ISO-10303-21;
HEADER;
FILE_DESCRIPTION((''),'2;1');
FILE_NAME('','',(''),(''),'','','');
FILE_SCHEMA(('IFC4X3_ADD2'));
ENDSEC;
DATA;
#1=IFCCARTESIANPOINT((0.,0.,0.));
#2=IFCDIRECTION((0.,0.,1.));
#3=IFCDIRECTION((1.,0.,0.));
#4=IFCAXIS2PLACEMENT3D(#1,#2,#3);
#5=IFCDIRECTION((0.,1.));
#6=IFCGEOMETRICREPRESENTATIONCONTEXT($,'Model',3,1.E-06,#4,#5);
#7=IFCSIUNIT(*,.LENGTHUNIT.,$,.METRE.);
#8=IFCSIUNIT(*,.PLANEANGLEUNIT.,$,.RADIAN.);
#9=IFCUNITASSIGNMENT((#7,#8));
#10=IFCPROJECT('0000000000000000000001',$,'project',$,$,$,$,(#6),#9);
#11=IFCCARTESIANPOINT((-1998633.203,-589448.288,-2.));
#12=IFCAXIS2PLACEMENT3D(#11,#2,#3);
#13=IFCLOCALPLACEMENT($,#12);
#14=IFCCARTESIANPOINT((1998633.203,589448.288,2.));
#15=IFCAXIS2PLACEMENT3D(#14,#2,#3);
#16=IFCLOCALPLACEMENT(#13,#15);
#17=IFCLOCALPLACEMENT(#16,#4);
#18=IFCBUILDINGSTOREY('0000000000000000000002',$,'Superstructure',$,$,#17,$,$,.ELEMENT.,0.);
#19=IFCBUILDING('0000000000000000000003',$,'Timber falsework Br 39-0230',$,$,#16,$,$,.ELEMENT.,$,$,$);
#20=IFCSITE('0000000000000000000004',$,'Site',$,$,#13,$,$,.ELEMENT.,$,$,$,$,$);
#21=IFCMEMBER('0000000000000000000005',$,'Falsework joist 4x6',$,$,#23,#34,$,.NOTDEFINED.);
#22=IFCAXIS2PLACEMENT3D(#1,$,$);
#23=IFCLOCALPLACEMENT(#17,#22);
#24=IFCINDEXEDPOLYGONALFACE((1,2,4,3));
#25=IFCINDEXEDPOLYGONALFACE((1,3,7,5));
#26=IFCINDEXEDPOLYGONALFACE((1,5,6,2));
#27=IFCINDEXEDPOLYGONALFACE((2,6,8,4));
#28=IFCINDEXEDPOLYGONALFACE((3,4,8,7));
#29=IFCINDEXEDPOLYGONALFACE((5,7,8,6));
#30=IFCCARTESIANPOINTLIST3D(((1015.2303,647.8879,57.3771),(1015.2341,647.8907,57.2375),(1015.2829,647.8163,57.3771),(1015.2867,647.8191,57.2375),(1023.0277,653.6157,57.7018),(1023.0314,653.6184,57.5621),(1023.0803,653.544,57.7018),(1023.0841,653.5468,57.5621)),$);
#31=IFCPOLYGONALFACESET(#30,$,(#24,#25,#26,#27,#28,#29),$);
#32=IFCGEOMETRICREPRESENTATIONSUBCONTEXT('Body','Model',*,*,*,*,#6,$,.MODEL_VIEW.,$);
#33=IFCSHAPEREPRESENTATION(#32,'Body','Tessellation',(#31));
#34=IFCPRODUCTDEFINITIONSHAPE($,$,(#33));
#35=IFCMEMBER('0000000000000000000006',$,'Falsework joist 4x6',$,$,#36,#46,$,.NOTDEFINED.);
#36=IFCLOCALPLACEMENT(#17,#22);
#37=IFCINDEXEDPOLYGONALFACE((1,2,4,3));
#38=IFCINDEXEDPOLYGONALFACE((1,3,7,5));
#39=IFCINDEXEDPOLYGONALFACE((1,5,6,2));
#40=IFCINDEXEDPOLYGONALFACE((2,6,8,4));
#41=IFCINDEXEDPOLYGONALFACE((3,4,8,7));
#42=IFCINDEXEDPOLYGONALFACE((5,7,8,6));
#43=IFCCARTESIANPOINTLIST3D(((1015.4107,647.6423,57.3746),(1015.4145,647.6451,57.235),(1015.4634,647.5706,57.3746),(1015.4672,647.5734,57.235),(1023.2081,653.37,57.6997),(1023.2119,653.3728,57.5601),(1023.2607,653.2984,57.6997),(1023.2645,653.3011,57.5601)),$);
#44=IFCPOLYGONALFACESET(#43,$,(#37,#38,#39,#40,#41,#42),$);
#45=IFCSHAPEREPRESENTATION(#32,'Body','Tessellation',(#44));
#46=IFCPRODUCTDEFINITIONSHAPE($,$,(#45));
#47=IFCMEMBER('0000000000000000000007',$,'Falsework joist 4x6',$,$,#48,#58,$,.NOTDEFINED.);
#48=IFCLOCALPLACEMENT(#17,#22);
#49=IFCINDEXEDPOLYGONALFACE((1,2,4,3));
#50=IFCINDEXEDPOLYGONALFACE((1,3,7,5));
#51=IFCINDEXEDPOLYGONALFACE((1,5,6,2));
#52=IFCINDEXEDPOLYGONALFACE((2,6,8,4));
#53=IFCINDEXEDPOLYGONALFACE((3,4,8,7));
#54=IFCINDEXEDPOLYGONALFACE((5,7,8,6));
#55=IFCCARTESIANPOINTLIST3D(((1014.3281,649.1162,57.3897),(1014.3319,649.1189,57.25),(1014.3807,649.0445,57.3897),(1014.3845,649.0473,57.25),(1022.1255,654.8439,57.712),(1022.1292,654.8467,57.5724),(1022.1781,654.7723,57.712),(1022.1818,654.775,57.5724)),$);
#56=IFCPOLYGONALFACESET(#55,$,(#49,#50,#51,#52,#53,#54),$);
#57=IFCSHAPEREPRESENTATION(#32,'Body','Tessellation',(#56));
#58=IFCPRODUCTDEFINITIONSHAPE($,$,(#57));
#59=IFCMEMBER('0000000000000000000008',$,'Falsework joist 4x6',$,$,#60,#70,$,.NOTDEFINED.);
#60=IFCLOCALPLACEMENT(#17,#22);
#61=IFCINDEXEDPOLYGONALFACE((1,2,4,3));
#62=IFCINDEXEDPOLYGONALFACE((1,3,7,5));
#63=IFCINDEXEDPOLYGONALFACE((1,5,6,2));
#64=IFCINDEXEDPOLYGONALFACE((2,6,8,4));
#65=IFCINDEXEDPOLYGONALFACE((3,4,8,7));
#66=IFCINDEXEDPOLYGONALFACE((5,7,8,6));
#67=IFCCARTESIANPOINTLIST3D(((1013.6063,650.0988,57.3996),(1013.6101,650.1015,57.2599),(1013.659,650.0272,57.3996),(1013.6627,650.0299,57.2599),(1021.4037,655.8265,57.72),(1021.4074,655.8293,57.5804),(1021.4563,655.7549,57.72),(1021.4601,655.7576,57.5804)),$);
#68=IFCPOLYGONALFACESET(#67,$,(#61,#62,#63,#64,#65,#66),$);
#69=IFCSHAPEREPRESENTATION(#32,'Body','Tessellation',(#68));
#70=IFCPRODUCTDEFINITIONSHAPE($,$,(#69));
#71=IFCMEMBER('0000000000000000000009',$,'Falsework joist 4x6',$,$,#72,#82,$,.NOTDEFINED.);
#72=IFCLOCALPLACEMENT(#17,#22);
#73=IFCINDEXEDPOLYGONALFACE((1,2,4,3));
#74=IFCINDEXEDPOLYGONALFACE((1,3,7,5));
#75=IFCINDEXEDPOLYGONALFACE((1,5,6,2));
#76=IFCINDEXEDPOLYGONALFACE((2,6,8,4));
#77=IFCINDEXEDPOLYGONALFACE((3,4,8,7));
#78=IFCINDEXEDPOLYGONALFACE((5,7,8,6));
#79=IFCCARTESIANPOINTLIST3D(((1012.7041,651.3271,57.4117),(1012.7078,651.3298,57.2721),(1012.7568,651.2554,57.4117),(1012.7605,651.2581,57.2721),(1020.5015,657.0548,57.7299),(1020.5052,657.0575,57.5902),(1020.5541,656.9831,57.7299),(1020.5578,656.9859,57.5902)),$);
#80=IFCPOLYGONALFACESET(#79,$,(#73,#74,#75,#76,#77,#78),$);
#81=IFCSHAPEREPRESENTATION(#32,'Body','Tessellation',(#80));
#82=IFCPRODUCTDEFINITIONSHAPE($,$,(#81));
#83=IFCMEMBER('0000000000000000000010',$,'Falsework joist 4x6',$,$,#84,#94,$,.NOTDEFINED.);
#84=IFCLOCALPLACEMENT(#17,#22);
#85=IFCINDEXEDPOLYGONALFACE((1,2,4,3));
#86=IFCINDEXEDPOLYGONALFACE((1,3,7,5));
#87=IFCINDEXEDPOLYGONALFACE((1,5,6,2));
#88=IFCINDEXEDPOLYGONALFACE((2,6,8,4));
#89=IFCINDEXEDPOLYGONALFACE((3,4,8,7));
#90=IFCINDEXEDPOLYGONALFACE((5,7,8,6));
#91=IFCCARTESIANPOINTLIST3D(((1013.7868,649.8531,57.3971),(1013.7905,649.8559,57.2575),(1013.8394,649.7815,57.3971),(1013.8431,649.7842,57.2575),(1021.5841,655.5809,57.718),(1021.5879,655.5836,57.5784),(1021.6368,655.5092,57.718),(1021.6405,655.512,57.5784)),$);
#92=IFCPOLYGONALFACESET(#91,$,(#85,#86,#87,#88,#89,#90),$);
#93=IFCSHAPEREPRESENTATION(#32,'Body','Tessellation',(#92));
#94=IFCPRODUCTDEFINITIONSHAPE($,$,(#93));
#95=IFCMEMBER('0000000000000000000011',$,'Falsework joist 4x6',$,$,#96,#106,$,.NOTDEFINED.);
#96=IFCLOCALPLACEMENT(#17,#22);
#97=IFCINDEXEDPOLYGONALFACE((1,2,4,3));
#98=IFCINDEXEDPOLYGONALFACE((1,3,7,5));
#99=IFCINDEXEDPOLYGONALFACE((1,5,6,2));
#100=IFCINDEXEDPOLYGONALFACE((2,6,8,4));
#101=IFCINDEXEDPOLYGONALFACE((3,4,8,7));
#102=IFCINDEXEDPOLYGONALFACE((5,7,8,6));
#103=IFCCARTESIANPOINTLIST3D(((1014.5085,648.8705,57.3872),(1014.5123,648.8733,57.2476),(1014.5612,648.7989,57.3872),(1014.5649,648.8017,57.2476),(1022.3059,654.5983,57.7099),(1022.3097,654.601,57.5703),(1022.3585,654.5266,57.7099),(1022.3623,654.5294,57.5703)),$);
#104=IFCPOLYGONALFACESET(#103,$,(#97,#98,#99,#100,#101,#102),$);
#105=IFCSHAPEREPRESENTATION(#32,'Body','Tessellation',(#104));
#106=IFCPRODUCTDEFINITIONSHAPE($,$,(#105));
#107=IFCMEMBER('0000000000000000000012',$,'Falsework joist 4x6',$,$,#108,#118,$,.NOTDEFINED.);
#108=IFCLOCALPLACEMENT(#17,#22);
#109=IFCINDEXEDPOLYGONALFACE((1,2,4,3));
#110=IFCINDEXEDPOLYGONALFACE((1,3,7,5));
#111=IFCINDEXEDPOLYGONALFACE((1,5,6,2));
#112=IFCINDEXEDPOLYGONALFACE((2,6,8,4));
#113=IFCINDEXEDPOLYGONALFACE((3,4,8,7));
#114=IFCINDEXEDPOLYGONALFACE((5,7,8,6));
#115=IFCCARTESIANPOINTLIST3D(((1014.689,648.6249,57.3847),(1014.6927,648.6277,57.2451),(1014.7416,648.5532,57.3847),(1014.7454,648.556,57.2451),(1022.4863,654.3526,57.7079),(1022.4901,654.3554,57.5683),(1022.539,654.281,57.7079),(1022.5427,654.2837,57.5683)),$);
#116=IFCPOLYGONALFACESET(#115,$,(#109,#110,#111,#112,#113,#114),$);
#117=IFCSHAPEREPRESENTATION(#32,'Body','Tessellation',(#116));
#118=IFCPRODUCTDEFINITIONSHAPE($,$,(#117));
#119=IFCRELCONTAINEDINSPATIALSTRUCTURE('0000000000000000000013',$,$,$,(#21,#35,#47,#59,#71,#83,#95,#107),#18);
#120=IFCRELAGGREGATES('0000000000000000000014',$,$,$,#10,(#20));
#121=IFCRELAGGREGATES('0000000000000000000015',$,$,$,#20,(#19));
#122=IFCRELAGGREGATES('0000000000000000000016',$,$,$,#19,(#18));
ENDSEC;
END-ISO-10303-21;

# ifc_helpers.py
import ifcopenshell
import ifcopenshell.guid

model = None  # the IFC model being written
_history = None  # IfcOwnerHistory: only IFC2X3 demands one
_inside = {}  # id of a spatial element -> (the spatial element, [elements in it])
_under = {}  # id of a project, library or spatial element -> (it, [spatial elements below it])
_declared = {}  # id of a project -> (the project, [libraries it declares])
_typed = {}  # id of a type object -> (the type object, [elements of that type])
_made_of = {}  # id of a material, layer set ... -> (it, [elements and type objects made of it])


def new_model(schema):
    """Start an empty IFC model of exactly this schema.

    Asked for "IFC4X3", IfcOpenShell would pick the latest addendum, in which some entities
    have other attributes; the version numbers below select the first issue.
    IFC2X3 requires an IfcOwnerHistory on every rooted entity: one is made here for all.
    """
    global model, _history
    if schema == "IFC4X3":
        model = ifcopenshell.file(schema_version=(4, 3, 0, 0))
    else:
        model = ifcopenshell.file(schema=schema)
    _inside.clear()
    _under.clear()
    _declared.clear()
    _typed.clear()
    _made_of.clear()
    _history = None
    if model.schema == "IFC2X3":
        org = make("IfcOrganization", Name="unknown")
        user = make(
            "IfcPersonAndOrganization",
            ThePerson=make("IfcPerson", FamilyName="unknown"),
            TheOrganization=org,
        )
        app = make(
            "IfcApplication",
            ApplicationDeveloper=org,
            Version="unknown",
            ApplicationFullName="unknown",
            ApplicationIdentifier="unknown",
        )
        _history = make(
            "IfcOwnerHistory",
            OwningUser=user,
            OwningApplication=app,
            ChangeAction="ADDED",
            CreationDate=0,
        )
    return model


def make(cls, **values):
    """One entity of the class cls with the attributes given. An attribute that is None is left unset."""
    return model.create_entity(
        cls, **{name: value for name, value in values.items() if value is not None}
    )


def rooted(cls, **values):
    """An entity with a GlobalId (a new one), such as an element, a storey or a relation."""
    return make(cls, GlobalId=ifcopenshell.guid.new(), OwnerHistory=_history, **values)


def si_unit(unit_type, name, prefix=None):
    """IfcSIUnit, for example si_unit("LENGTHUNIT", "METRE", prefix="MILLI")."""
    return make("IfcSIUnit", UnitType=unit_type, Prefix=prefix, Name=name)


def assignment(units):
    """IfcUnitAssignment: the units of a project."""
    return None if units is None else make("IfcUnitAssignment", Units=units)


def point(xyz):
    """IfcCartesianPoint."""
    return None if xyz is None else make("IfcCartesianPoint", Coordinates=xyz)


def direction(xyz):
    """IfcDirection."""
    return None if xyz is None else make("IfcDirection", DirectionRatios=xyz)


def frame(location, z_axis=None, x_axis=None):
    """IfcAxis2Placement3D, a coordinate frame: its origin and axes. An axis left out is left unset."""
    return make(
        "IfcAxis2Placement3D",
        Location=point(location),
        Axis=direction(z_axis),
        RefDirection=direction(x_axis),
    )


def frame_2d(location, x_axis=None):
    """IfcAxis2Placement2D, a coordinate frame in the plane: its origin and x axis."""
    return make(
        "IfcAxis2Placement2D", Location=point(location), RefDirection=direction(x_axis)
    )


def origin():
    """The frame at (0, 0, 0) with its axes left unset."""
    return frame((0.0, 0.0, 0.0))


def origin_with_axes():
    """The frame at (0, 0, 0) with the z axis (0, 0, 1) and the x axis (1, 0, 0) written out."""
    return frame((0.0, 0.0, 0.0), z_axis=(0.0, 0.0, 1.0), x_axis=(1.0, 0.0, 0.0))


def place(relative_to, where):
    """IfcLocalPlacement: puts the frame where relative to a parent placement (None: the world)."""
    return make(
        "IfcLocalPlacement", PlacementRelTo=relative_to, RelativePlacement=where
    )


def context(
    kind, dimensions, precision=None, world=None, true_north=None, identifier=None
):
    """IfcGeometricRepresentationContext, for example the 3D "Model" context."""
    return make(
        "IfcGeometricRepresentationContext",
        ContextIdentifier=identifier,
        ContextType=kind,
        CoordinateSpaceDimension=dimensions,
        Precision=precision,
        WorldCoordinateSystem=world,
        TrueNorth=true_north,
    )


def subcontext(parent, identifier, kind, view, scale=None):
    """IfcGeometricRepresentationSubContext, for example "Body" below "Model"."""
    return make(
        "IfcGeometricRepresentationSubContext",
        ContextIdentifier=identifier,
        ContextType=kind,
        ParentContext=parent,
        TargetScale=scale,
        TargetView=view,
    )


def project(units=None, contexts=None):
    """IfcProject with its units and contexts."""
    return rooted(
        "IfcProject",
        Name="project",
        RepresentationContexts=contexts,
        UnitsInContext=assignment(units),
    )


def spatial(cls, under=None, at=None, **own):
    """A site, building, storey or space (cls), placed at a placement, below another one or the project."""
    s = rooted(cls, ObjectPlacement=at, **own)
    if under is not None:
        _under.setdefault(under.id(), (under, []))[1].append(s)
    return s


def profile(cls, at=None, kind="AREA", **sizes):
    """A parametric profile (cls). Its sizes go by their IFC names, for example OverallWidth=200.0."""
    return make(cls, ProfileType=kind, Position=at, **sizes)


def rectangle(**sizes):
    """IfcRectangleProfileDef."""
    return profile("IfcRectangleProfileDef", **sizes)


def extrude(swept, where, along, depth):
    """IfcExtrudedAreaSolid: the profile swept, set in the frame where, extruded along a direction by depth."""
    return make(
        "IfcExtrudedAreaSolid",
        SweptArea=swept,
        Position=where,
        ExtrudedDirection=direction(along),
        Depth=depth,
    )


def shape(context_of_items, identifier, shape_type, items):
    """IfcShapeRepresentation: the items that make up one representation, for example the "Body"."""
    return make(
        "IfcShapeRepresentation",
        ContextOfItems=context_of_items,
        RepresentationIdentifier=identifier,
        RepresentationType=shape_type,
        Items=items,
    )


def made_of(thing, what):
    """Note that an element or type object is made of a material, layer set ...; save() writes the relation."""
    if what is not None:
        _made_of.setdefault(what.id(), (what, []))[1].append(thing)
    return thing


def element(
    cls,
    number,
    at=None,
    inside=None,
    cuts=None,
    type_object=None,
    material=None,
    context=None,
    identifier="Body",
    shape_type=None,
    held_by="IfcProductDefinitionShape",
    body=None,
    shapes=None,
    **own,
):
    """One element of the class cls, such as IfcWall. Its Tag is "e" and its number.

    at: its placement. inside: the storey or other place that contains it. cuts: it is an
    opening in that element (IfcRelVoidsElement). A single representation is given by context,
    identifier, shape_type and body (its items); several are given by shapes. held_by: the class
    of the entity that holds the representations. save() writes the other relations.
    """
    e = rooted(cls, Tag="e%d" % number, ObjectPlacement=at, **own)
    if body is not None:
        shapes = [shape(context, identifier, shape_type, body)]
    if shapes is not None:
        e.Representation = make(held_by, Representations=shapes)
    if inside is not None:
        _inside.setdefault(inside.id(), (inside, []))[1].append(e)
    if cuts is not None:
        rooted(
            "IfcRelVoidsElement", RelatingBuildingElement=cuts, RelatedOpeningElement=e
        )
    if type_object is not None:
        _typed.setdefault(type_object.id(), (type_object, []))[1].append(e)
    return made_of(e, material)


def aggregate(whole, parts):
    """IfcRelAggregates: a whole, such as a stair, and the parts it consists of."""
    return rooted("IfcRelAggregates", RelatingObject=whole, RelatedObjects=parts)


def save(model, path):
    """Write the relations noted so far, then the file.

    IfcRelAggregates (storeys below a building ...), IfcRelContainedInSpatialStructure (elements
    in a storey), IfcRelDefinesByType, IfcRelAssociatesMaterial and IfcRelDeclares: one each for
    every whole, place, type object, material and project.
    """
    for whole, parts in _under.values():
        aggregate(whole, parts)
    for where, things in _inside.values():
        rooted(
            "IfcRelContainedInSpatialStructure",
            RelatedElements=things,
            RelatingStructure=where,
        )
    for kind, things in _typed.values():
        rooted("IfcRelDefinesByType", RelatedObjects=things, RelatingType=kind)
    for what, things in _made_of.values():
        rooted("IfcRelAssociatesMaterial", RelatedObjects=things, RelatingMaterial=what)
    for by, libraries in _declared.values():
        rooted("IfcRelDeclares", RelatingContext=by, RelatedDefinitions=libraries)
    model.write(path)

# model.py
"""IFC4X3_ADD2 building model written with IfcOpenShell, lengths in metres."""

from ifc_helpers import new_model, si_unit, direction, frame, frame_2d, origin, origin_with_axes, place, context, subcontext, project, spatial, rectangle, extrude, element, save


model = new_model("IFC4X3_ADD2")

# Units and contexts
model_context = context("Model", 3, precision=1e-06, world=origin_with_axes(), true_north=direction((0.0, 1.0)))
body_context = subcontext(model_context, "Body", "Model", "MODEL_VIEW")
ifc_project = project(units=[si_unit("LENGTHUNIT", "METRE"), si_unit("PLANEANGLEUNIT", "RADIAN")], contexts=[model_context])

# Site, building, storey
site_placement = place(None, frame((-1998633.203, -589448.288, -2.0), z_axis=(0.0, 0.0, 1.0), x_axis=(1.0, 0.0, 0.0)))
site = spatial("IfcSite", under=ifc_project, at=site_placement, Name="Site", CompositionType="ELEMENT")
building_placement = place(site_placement, frame((1998633.203, 589448.288, 2.0), z_axis=(0.0, 0.0, 1.0), x_axis=(1.0, 0.0, 0.0)))
building = spatial("IfcBuilding", under=site, at=building_placement, Name="Timber falsework Br 39-0230", CompositionType="ELEMENT")
storey_placement = place(building_placement, origin_with_axes())
storey = spatial("IfcBuildingStorey", under=building, at=storey_placement, Name="Superstructure", CompositionType="ELEMENT", Elevation=0.0)

# Members
member_1_placement = place(storey_placement, frame((1015.2604, 647.8549, 57.2375), z_axis=(0.805475, 0.59168, 0.033535), x_axis=(-0.592013, 0.805928, 0.0)))
element("IfcMember", 1, at=member_1_placement, inside=storey, Name="Falsework joist 4x6", PredefinedType="NOTDEFINED", context=body_context, shape_type="SweptSolid", body=[
    extrude(rectangle(XDim=0.0889, YDim=0.1397, at=frame_2d((0.0, 0.0698))), origin(), (0.0, 0.0, 1.0), 9.6804),
])
member_2_placement = place(storey_placement, frame((1015.4408, 647.6092, 57.235), z_axis=(0.805474, 0.591679, 0.033583), x_axis=(-0.592013, 0.805928, 0.0)))
element("IfcMember", 2, at=member_2_placement, inside=storey, Name="Falsework joist 4x6", PredefinedType="NOTDEFINED", context=body_context, shape_type="SweptSolid", body=[
    extrude(rectangle(XDim=0.0889, YDim=0.1397, at=frame_2d((0.0, 0.0698))), origin(), (0.0, 0.0, 1.0), 9.6805),
])
member_3_placement = place(storey_placement, frame((1014.3582, 649.0831, 57.25), z_axis=(0.805481, 0.591685, 0.033295), x_axis=(-0.592013, 0.805928, 0.0)))
element("IfcMember", 3, at=member_3_placement, inside=storey, Name="Falsework joist 4x6", PredefinedType="NOTDEFINED", context=body_context, shape_type="SweptSolid", body=[
    extrude(rectangle(XDim=0.0889, YDim=0.1397, at=frame_2d((0.0, 0.0698))), origin(), (0.0, 0.0, 1.0), 9.6804),
])
member_4_placement = place(storey_placement, frame((1013.6364, 650.0657, 57.2599), z_axis=(0.805487, 0.591689, 0.033103), x_axis=(-0.592013, 0.805928, 0.0)))
element("IfcMember", 4, at=member_4_placement, inside=storey, Name="Falsework joist 4x6", PredefinedType="NOTDEFINED", context=body_context, shape_type="SweptSolid", body=[
    extrude(rectangle(XDim=0.0889, YDim=0.1397, at=frame_2d((0.0, 0.0698))), origin(), (0.0, 0.0, 1.0), 9.6803),
])
member_5_placement = place(storey_placement, frame((1012.7342, 651.2939, 57.2721), z_axis=(0.805493, 0.591693, 0.032862), x_axis=(-0.592013, 0.805928, 0.0)))
element("IfcMember", 5, at=member_5_placement, inside=storey, Name="Falsework joist 4x6", PredefinedType="NOTDEFINED", context=body_context, shape_type="SweptSolid", body=[
    extrude(rectangle(XDim=0.0889, YDim=0.1397, at=frame_2d((0.0, 0.0698))), origin(), (0.0, 0.0, 1.0), 9.6802),
])
member_6_placement = place(storey_placement, frame((1013.8168, 649.8201, 57.2575), z_axis=(0.805485, 0.591688, 0.033151), x_axis=(-0.592013, 0.805928, 0.0)))
element("IfcMember", 6, at=member_6_placement, inside=storey, Name="Falsework joist 4x6", PredefinedType="NOTDEFINED", context=body_context, shape_type="SweptSolid", body=[
    extrude(rectangle(XDim=0.0889, YDim=0.1397, at=frame_2d((0.0, 0.0698))), origin(), (0.0, 0.0, 1.0), 9.6803),
])
member_7_placement = place(storey_placement, frame((1014.5386, 648.8375, 57.2476), z_axis=(0.80548, 0.591684, 0.033343), x_axis=(-0.592013, 0.805928, 0.0)))
element("IfcMember", 7, at=member_7_placement, inside=storey, Name="Falsework joist 4x6", PredefinedType="NOTDEFINED", context=body_context, shape_type="SweptSolid", body=[
    extrude(rectangle(XDim=0.0889, YDim=0.1397, at=frame_2d((0.0, 0.0698))), origin(), (0.0, 0.0, 1.0), 9.6804),
])
member_8_placement = place(storey_placement, frame((1014.7191, 648.5918, 57.2451), z_axis=(0.805479, 0.591683, 0.033391), x_axis=(-0.592013, 0.805928, 0.0)))
element("IfcMember", 8, at=member_8_placement, inside=storey, Name="Falsework joist 4x6", PredefinedType="NOTDEFINED", context=body_context, shape_type="SweptSolid", body=[
    extrude(rectangle(XDim=0.0889, YDim=0.1397, at=frame_2d((0.0, 0.0698))), origin(), (0.0, 0.0, 1.0), 9.6804),
])

save(model, "model.ifc")
